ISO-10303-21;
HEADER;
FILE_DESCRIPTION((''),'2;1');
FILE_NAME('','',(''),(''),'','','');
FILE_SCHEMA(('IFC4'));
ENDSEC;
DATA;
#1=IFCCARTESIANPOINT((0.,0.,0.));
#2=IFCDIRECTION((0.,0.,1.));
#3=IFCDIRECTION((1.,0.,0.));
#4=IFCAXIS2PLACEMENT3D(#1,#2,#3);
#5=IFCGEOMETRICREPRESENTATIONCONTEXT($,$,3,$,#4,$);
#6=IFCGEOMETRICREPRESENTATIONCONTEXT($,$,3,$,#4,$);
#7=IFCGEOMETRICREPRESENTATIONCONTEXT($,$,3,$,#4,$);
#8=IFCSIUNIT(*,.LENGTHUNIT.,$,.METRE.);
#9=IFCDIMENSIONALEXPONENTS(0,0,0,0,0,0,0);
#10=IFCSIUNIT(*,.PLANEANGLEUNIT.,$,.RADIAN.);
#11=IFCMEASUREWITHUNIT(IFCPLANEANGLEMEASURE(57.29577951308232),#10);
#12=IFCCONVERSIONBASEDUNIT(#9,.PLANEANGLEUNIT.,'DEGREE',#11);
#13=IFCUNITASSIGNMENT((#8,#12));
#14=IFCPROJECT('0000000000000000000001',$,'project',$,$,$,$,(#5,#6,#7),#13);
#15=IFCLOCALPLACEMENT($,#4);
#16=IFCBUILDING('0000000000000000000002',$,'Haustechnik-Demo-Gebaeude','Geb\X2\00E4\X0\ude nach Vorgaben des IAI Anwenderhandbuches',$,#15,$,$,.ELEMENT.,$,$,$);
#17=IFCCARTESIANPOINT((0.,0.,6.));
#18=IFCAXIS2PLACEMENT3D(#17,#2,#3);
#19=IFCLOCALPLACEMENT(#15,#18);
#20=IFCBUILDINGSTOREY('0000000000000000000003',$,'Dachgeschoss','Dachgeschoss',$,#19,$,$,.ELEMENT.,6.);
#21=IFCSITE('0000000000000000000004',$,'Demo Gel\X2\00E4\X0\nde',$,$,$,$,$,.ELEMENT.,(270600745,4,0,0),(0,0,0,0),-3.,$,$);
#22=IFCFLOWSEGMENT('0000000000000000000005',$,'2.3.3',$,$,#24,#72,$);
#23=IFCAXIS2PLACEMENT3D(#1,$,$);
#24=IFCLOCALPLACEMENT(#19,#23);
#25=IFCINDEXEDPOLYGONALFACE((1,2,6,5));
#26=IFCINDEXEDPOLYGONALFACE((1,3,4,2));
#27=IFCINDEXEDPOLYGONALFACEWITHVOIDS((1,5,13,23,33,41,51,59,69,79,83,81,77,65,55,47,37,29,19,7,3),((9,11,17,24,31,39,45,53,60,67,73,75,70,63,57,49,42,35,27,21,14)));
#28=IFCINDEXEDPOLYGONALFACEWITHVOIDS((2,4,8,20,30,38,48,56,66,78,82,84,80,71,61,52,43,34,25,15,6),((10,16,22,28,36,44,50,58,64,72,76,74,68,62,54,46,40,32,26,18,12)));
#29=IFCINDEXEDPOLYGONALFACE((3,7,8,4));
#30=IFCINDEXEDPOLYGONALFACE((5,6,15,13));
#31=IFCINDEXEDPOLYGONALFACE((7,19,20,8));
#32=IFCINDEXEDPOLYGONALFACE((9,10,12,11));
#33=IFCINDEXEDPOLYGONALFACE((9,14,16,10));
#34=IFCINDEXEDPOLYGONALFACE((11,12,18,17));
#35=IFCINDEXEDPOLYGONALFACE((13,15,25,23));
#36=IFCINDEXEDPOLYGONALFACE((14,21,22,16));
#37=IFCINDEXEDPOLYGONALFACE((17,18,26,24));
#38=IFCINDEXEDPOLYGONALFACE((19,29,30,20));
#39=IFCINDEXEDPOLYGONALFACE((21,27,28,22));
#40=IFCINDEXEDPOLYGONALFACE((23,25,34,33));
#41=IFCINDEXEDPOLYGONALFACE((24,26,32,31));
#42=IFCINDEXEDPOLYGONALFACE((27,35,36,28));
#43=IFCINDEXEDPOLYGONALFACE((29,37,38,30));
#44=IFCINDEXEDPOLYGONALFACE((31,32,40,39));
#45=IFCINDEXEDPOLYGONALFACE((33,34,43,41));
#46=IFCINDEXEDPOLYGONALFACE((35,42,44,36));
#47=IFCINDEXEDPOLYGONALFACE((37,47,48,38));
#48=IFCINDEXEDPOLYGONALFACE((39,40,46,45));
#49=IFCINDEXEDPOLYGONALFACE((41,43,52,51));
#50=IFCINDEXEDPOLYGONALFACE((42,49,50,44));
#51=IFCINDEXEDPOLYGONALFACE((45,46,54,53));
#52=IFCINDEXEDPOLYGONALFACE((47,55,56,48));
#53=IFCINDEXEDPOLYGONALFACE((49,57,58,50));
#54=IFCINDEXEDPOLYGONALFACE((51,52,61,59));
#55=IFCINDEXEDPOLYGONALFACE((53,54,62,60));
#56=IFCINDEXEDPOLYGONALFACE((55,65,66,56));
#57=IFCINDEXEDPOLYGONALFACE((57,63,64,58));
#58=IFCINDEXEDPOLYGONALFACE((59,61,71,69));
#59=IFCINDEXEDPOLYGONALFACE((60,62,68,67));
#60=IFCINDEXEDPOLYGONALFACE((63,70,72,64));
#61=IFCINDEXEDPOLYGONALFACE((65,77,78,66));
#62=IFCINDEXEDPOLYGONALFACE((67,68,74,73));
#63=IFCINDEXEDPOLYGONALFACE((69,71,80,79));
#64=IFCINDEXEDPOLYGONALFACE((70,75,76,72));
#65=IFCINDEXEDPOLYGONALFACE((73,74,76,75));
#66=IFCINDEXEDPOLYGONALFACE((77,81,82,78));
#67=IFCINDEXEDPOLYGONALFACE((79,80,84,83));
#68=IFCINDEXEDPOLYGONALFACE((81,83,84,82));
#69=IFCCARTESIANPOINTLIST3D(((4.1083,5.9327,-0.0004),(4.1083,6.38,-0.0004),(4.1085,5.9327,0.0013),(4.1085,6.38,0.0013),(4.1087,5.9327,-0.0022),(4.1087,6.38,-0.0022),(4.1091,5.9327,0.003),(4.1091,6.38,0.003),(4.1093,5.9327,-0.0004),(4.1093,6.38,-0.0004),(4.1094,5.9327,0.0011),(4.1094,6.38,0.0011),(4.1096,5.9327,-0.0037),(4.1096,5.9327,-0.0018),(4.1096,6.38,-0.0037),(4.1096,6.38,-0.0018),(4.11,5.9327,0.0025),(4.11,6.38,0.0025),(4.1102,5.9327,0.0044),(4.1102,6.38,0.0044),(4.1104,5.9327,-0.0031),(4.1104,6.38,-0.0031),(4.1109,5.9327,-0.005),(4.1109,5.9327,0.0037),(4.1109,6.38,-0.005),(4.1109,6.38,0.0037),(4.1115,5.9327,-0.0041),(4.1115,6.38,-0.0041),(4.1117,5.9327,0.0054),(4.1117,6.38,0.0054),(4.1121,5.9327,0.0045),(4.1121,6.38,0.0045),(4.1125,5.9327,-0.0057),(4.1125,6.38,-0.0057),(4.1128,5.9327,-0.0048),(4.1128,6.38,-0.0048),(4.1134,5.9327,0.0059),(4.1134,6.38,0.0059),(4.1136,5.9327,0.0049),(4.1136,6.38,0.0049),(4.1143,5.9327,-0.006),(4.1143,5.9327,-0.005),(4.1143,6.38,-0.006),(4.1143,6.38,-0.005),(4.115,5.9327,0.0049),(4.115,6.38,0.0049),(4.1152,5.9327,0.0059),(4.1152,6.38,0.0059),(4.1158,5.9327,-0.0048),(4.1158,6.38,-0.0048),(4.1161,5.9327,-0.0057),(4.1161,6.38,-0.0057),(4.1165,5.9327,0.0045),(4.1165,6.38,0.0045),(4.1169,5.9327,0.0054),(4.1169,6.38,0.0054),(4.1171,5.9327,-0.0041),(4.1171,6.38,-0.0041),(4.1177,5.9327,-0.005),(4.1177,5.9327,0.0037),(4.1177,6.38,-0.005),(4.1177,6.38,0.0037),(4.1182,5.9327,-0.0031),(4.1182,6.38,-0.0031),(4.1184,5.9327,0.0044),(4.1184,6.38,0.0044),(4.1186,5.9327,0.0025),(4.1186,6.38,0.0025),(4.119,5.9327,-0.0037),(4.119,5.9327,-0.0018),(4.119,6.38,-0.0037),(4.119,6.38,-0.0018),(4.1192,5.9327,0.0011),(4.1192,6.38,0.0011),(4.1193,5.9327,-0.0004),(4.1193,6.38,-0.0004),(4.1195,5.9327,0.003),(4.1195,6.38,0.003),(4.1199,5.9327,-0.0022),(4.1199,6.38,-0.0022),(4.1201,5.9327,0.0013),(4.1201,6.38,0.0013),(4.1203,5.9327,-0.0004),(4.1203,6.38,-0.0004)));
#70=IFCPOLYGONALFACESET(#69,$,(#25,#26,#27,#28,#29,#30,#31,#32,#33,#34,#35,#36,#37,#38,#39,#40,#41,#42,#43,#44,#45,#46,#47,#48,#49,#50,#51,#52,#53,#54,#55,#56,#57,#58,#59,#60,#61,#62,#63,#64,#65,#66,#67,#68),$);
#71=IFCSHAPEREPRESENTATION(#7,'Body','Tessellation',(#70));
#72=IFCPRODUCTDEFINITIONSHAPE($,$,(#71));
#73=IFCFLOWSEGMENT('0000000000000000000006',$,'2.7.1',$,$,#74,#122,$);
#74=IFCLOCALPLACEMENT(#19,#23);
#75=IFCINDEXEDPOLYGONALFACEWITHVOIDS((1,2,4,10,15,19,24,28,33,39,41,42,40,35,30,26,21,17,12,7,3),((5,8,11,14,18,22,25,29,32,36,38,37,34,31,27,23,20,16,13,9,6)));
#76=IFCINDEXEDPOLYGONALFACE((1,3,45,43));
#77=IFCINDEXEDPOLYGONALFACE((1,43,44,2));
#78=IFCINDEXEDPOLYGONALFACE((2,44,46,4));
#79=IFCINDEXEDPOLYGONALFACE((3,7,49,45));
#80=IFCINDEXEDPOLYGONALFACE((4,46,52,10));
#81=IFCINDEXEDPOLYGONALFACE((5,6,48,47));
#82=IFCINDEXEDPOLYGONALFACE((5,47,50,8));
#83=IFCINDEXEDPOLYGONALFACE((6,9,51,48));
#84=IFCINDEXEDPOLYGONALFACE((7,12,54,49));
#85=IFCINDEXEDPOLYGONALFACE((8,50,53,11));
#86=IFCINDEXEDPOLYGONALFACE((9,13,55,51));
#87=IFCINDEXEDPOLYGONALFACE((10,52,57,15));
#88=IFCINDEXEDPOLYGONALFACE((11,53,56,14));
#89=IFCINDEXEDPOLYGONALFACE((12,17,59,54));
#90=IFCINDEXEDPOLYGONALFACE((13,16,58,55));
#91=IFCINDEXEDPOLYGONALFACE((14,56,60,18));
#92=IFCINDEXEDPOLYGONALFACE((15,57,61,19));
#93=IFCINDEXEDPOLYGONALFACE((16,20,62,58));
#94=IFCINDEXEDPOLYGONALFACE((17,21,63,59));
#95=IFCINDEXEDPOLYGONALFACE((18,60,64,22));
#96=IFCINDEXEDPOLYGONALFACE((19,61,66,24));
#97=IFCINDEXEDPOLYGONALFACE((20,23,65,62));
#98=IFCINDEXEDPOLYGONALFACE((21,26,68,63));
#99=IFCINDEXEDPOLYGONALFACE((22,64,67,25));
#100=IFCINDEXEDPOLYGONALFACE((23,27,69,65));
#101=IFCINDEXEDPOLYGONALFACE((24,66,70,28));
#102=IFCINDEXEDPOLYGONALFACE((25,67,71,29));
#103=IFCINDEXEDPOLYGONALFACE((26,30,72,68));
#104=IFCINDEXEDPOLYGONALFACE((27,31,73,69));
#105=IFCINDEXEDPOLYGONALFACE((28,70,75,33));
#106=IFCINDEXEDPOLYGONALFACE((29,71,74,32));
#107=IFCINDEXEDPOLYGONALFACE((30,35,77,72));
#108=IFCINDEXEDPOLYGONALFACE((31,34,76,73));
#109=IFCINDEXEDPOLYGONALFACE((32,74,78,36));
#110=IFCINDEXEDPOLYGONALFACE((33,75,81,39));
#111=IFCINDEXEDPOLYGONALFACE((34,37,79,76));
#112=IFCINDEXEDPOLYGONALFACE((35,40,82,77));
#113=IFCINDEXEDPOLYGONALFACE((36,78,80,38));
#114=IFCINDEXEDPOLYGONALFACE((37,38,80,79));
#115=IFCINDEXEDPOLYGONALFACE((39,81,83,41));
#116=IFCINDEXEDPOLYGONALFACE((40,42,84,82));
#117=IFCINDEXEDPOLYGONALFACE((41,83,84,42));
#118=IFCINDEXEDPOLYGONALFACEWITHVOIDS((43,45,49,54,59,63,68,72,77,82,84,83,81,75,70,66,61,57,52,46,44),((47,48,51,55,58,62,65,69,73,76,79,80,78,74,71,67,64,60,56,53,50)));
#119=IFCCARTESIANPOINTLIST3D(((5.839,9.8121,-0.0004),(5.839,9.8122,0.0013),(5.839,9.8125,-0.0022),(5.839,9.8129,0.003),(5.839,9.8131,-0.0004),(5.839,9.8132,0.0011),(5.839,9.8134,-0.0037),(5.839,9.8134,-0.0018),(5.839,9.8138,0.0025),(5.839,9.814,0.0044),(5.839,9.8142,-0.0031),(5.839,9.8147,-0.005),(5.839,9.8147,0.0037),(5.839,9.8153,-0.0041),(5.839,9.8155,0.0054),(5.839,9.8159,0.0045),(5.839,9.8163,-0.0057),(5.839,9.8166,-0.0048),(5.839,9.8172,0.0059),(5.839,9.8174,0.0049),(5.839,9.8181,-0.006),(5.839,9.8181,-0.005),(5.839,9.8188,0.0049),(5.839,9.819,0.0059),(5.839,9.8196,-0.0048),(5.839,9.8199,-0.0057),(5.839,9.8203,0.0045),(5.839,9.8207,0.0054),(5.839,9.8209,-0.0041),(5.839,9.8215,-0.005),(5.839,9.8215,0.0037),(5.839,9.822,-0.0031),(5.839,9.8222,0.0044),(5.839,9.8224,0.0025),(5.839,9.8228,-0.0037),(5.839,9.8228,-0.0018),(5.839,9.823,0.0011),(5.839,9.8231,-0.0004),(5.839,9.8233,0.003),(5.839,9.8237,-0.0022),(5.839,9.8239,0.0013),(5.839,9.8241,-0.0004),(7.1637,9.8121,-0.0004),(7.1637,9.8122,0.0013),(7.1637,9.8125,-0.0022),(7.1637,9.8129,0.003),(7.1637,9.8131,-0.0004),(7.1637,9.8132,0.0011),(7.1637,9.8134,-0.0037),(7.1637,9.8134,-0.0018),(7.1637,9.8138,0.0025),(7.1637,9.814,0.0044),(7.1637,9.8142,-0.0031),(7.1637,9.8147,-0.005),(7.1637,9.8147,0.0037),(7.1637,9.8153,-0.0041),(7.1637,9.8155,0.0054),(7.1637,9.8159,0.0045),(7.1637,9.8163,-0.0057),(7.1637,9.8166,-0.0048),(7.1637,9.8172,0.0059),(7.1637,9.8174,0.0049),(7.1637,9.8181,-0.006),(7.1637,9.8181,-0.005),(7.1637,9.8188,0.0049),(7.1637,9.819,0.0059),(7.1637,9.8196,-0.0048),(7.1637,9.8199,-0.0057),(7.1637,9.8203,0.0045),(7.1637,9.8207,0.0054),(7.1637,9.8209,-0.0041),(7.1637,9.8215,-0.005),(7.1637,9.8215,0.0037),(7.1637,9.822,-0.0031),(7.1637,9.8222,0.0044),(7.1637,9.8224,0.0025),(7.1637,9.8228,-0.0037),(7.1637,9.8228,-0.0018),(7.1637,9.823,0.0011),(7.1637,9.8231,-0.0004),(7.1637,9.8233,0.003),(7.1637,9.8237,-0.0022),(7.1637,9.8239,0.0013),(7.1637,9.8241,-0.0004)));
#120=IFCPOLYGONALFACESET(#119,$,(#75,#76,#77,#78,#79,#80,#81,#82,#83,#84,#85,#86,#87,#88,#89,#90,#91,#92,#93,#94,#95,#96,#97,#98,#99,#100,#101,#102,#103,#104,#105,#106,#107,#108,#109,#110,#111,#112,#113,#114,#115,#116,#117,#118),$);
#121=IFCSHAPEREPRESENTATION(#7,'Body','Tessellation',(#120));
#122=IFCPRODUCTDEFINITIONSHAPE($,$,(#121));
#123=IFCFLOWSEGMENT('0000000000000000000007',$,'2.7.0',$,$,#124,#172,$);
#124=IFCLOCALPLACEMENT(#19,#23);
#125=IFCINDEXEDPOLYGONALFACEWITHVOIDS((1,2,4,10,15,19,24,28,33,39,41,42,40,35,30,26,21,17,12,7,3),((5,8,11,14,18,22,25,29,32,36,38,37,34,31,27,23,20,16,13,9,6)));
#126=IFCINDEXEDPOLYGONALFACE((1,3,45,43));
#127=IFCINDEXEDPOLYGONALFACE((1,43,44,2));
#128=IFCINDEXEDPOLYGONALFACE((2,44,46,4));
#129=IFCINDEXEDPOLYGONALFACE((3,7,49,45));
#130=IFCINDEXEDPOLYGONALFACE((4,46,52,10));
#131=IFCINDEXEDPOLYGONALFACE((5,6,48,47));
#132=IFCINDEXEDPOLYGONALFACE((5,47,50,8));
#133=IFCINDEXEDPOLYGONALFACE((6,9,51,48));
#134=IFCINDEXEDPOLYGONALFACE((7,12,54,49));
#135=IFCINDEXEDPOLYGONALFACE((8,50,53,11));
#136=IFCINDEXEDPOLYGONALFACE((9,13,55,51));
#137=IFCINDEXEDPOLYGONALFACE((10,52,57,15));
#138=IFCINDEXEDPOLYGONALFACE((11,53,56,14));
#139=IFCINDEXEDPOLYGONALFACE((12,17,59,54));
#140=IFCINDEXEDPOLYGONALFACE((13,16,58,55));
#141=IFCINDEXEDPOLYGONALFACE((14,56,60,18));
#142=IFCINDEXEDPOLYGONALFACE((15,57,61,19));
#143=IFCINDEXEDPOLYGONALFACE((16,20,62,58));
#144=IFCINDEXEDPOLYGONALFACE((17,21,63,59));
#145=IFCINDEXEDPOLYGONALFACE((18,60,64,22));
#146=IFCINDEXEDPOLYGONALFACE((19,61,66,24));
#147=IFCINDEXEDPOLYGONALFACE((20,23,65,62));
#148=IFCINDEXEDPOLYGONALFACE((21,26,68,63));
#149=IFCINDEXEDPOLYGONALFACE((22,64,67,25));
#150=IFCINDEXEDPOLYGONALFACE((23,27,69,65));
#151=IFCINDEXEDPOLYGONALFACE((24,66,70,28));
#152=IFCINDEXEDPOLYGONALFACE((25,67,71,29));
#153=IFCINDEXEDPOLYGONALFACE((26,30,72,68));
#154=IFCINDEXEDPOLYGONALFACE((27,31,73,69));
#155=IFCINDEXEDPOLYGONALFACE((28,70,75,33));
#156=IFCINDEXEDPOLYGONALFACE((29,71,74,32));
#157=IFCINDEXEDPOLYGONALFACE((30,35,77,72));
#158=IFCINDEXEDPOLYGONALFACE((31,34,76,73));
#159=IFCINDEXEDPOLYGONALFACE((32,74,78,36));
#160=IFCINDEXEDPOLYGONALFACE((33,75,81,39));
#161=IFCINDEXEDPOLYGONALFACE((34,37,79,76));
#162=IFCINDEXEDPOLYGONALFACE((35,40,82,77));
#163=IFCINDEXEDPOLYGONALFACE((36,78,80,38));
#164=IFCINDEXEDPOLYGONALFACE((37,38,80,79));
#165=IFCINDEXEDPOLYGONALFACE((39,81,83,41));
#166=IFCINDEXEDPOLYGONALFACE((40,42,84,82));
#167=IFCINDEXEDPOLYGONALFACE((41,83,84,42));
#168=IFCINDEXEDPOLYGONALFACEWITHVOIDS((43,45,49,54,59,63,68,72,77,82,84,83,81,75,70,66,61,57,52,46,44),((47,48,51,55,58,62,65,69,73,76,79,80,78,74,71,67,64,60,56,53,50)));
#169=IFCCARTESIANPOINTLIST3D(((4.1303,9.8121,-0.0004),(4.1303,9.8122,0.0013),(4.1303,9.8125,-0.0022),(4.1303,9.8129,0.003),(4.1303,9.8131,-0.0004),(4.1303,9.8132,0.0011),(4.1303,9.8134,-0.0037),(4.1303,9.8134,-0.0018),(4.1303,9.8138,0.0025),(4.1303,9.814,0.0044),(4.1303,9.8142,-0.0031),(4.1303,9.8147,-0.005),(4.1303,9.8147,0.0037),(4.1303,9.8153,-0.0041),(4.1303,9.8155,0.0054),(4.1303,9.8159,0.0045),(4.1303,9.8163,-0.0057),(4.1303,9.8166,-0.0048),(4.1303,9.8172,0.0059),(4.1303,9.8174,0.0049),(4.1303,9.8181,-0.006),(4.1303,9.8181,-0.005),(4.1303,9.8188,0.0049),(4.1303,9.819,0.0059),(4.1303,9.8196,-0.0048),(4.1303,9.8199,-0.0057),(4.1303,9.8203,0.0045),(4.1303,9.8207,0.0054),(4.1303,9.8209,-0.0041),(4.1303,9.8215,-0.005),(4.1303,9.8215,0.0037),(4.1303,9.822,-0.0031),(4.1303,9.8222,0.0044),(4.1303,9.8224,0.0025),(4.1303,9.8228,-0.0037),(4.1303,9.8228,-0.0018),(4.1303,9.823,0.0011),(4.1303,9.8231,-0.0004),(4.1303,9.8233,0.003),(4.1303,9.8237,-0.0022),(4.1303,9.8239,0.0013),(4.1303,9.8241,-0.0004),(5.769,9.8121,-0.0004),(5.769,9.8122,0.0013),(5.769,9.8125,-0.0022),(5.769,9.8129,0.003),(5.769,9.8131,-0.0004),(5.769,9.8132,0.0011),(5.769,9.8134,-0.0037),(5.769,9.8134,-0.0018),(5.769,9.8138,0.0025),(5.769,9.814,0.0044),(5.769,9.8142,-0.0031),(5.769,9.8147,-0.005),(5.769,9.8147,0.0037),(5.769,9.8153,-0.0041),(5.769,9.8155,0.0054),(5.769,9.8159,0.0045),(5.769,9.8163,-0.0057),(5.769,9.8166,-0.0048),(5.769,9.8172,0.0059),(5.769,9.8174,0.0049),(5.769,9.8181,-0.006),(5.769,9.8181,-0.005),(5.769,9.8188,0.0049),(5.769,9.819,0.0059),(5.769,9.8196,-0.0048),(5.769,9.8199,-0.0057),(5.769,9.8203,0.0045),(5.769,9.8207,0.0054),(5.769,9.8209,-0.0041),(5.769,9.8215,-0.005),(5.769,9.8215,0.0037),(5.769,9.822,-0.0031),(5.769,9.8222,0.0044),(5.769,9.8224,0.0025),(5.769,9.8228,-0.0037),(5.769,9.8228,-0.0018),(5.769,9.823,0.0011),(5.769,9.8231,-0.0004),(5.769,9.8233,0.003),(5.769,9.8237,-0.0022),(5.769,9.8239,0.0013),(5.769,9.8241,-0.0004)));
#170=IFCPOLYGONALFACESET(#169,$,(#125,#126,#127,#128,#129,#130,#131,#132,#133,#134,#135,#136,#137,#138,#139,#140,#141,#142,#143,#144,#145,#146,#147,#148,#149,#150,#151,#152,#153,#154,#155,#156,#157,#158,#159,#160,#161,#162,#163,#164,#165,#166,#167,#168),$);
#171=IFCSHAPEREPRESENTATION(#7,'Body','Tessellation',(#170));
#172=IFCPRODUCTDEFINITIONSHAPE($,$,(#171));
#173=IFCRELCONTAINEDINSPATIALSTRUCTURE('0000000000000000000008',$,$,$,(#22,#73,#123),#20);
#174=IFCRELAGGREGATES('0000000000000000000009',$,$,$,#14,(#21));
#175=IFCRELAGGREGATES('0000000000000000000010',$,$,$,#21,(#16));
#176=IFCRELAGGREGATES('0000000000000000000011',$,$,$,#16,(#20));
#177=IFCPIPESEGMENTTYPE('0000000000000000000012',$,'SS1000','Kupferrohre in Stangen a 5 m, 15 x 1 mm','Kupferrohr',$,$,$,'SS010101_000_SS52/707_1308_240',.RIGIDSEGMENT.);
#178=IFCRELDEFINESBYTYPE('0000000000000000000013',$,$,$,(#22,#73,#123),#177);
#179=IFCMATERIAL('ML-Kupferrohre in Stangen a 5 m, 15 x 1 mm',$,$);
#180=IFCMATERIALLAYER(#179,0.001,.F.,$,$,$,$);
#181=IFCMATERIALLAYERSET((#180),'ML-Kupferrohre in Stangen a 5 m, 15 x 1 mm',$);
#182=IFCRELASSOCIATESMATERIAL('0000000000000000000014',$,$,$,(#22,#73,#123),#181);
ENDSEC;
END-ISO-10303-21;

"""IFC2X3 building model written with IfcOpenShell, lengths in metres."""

from ifc_helpers import new_model, entity, si_unit, converted_unit, frame, origin_with_axes, origin_2d_with_axis, place, context, project, spatial, hollow_circle, extrude, material, layer, layer_set, layer_usage, type_object, element, save


model = new_model("IFC2X3")

# Units and contexts
context_of_model_1 = context(None, 3, world=origin_with_axes())
context_of_model_2 = context(None, 3, world=origin_with_axes())
context_of_model_3 = context(None, 3, world=origin_with_axes())
ifc_project = project(units=[si_unit("LENGTHUNIT", "METRE"), converted_unit("PLANEANGLEUNIT", "DEGREE", entity("IfcPlaneAngleMeasure", 57.29577951308232), si_unit("PLANEANGLEUNIT", "RADIAN"), dimensions=[0, 0, 0, 0, 0, 0, 0])], contexts=[context_of_model_1, context_of_model_2, context_of_model_3])

# Site, building, storey
site = spatial("IfcSite", under=ifc_project, Name="Demo Gelände", CompositionType="ELEMENT", RefLatitude=(270600745, 4, 0, 0), RefLongitude=(0, 0, 0, 0), RefElevation=-3.0)
building_placement = place(None, origin_with_axes())
building = spatial("IfcBuilding", under=site, at=building_placement, Name="Haustechnik-Demo-Gebaeude", Description="Gebäude nach Vorgaben des IAI Anwenderhandbuches", CompositionType="ELEMENT")
storey_placement = place(building_placement, frame((0.0, 0.0, 6.0), z_axis=(0.0, 0.0, 1.0), x_axis=(1.0, 0.0, 0.0)))
storey = spatial("IfcBuildingStorey", under=building, at=storey_placement, Name="Dachgeschoss", Description="Dachgeschoss", CompositionType="ELEMENT", Elevation=6.0)

# Flow segments
ifc_material = material(Name="ML-Kupferrohre in Stangen a 5 m, 15 x 1 mm")
ifc_layer = layer(ifc_material, 0.001, ventilated=False)
ifc_layer_set = layer_set([ifc_layer], Name="ML-Kupferrohre in Stangen a 5 m, 15 x 1 mm")
ifc_layer_usage = layer_usage(ifc_layer_set, "AXIS2", "POSITIVE", 0.0)
pipe_segment_type_1 = type_object("IfcPipeSegmentType", Name="SS1000", Description="Kupferrohre in Stangen a 5 m, 15 x 1 mm", ApplicableOccurrence="Kupferrohr", ElementType="SS010101_000_SS52/707_1308_240", PredefinedType="RIGIDSEGMENT")
flow_segment_1_placement = place(storey_placement, frame((4.1143, 5.9327, 0.0), z_axis=(0.0, 1.0, 0.0), x_axis=(0.0, 0.0, -1.0)))
element("IfcFlowSegment", 1, at=flow_segment_1_placement, inside=storey, type_object=pipe_segment_type_1, material=ifc_layer_usage, Name="2.3.3", context=context_of_model_3, shape_type="SweptSolid", body=[
    extrude(hollow_circle(Radius=0.006, WallThickness=0.001, at=origin_2d_with_axis()), origin_with_axes(), (0.0, 0.0, 1.0), 0.4473),
])
flow_segment_2_placement = place(storey_placement, frame((7.1637, 9.8181, 0.0), z_axis=(-1.0, 0.0, 0.0), x_axis=(0.0, 0.0, -1.0)))
element("IfcFlowSegment", 2, at=flow_segment_2_placement, inside=storey, type_object=pipe_segment_type_1, material=ifc_layer_usage, Name="2.7.1", context=context_of_model_3, shape_type="SweptSolid", body=[
    extrude(hollow_circle(Radius=0.006, WallThickness=0.001, at=origin_2d_with_axis()), origin_with_axes(), (0.0, 0.0, 1.0), 1.3248),
])
flow_segment_3_placement = place(storey_placement, frame((5.769, 9.8181, 0.0), z_axis=(-1.0, 0.0, 0.0), x_axis=(0.0, 0.0, -1.0)))
element("IfcFlowSegment", 3, at=flow_segment_3_placement, inside=storey, type_object=pipe_segment_type_1, material=ifc_layer_usage, Name="2.7.0", context=context_of_model_3, shape_type="SweptSolid", body=[
    extrude(hollow_circle(Radius=0.006, WallThickness=0.001, at=origin_2d_with_axis()), origin_with_axes(), (0.0, 0.0, 1.0), 1.6387),
])

save(model, "model.ifc")
